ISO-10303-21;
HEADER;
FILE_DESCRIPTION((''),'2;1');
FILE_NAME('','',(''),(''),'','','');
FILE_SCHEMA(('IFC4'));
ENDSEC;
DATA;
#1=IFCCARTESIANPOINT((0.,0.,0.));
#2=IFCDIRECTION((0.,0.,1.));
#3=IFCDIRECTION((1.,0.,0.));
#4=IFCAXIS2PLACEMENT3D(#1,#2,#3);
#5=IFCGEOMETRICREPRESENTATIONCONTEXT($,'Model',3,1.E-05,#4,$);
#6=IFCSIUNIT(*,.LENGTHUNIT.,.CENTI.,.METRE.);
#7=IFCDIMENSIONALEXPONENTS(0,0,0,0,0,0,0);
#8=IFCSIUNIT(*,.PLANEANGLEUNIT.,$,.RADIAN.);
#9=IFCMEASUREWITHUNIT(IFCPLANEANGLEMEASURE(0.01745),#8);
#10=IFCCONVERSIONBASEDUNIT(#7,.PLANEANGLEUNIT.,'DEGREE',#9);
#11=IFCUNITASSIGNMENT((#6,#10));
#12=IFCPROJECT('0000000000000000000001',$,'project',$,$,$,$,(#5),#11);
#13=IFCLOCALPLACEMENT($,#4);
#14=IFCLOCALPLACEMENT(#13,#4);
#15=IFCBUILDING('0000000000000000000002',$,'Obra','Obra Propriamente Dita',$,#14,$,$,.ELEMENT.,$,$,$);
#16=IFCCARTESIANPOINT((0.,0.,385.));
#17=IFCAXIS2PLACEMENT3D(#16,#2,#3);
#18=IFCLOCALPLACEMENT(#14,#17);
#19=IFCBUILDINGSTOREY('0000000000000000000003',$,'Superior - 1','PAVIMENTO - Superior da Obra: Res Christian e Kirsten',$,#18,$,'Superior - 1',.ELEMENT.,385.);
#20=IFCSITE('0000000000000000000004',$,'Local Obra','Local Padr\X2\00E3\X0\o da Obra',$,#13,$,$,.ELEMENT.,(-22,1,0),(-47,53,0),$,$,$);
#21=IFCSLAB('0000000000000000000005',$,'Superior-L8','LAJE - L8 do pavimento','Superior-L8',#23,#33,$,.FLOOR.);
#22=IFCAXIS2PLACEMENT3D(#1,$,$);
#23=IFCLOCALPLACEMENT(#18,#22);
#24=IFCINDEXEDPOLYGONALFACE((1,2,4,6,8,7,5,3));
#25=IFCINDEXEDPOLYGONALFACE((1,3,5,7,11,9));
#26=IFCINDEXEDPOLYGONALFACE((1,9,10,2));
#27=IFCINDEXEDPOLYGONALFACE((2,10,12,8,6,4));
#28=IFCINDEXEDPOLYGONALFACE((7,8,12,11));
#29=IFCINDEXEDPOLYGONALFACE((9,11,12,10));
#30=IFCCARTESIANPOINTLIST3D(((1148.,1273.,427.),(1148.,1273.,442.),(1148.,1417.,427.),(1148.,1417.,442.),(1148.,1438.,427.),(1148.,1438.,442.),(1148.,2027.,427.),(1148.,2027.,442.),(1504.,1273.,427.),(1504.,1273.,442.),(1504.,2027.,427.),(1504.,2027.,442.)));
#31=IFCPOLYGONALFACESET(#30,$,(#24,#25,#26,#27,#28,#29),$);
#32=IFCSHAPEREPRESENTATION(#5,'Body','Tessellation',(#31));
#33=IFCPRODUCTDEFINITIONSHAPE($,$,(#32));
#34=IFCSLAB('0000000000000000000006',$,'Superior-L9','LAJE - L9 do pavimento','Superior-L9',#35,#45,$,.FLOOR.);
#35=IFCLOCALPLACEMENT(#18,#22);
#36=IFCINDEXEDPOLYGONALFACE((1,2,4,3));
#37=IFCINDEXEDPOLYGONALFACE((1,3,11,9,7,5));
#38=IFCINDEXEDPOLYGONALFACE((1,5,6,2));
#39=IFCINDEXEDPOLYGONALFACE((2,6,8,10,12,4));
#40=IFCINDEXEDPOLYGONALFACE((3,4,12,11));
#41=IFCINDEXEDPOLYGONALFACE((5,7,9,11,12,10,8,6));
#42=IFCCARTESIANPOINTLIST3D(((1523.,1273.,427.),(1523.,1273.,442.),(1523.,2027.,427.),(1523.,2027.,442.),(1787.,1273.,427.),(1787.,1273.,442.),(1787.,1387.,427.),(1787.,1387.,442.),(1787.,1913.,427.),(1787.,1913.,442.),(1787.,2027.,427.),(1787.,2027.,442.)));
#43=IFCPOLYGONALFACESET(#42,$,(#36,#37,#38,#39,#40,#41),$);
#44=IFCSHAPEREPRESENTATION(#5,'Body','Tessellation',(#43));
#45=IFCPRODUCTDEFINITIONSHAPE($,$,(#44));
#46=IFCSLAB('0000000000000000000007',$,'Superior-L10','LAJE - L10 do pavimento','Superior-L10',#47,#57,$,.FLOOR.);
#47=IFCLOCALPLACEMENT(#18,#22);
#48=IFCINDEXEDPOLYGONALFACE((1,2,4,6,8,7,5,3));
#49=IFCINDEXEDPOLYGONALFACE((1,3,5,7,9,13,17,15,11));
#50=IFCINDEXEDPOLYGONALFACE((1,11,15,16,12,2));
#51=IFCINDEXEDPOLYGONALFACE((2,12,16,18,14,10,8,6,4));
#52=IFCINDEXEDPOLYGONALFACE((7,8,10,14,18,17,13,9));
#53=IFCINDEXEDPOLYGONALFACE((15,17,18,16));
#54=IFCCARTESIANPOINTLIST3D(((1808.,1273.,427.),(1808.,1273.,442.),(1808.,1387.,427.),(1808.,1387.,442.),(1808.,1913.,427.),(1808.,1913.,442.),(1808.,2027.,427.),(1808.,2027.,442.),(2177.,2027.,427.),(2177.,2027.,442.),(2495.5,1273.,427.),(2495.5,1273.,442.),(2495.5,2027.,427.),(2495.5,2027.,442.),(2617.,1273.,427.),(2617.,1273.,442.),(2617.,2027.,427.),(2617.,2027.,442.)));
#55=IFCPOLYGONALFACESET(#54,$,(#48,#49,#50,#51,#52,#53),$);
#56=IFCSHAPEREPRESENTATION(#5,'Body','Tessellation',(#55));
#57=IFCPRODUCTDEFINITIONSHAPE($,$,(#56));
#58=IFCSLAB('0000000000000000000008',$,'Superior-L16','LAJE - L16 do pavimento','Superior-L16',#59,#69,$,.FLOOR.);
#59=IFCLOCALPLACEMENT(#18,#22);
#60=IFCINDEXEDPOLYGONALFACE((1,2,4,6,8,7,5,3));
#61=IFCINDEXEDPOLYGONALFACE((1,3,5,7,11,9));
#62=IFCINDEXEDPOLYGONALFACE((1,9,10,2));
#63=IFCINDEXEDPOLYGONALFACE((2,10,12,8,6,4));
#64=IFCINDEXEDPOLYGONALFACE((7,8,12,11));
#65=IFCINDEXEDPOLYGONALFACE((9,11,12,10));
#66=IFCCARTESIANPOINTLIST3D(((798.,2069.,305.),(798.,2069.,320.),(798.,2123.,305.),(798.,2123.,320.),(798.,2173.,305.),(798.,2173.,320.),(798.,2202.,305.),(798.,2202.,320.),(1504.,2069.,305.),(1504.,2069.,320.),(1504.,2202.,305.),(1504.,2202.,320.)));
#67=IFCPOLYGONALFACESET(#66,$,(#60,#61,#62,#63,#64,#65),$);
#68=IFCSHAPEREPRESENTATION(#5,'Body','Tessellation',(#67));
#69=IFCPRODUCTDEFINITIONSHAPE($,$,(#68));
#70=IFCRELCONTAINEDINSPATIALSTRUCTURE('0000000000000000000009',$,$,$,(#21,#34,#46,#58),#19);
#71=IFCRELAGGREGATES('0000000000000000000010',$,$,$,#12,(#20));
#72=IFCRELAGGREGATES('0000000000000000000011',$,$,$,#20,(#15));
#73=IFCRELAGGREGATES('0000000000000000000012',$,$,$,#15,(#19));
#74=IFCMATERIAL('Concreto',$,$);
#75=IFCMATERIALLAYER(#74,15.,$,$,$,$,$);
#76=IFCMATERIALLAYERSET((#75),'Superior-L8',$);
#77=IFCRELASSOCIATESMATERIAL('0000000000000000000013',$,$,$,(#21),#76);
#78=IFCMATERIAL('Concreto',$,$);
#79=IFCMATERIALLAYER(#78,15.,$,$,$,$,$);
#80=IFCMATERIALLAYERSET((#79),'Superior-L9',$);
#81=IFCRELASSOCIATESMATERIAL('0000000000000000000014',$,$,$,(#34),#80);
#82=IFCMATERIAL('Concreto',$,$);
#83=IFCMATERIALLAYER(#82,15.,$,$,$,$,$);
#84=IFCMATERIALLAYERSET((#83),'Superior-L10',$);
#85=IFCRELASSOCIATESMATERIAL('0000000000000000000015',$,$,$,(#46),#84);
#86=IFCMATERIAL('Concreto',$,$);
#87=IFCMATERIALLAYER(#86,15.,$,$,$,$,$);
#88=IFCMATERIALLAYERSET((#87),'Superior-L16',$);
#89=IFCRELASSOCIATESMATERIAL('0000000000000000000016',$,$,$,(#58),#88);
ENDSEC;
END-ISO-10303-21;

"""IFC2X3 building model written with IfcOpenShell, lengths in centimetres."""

from ifc_helpers import new_model, entity, si_unit, converted_unit, frame, origin_with_axes, place, context, project, spatial, polyline, outline, extrude, material, layer, layer_set, layer_usage, element, save


model = new_model("IFC2X3")

# Units and contexts
model_context = context("Model", 3, precision=1e-05, world=origin_with_axes())
ifc_project = project(units=[si_unit("LENGTHUNIT", "METRE", prefix="CENTI"), converted_unit("PLANEANGLEUNIT", "DEGREE", entity("IfcPlaneAngleMeasure", 0.01745), si_unit("PLANEANGLEUNIT", "RADIAN"), dimensions=[0, 0, 0, 0, 0, 0, 0])], contexts=[model_context])

# Site, building, storey
site_placement = place(None, origin_with_axes())
site = spatial("IfcSite", under=ifc_project, at=site_placement, Name="Local Obra", Description="Local Padrão da Obra", CompositionType="ELEMENT", RefLatitude=(-22, 1, 0), RefLongitude=(-47, 53, 0))
building_placement = place(site_placement, origin_with_axes())
building = spatial("IfcBuilding", under=site, at=building_placement, Name="Obra", Description="Obra Propriamente Dita", CompositionType="ELEMENT")
storey_placement = place(building_placement, frame((0.0, 0.0, 385.0), z_axis=(0.0, 0.0, 1.0), x_axis=(1.0, 0.0, 0.0)))
storey = spatial("IfcBuildingStorey", under=building, at=storey_placement, Name="Superior - 1", Description="PAVIMENTO - Superior da Obra: Res Christian e Kirsten", LongName="Superior - 1", CompositionType="ELEMENT", Elevation=385.0)

# Slabs
ifc_material_1 = material(Name="Concreto")
ifc_layer_1 = layer(ifc_material_1, 15.0)
ifc_layer_set_1 = layer_set([ifc_layer_1], Name="Superior-L8")
ifc_layer_usage_1 = layer_usage(ifc_layer_set_1, "AXIS3", "POSITIVE", 0.0)
slab_1_placement = place(storey_placement, frame((1504.0, 1273.0, 427.0), z_axis=(0.0, 0.0, 1.0), x_axis=(1.0, 0.0, 0.0)))
element("IfcSlab", 1, at=slab_1_placement, inside=storey, material=ifc_layer_usage_1, Name="Superior-L8", Description="LAJE - L8 do pavimento", ObjectType="Superior-L8", PredefinedType="FLOOR", context=model_context, shape_type="SweptSolid", body=[
    extrude(outline(polyline([(0.0, 754.0), (-356.0, 754.0), (-356.0, 165.0), (-356.0, 144.0), (-356.0, 0.0), (0.0, 0.0), (0.0, 754.0)])), origin_with_axes(), (0.0, 0.0, 1.0), 15.0),
])
ifc_material_2 = material(Name="Concreto")
ifc_layer_2 = layer(ifc_material_2, 15.0)
ifc_layer_set_2 = layer_set([ifc_layer_2], Name="Superior-L9")
ifc_layer_usage_2 = layer_usage(ifc_layer_set_2, "AXIS3", "POSITIVE", 0.0)
slab_2_placement = place(storey_placement, frame((1787.0, 1913.0, 427.0), z_axis=(0.0, 0.0, 1.0), x_axis=(1.0, 0.0, 0.0)))
element("IfcSlab", 2, at=slab_2_placement, inside=storey, material=ifc_layer_usage_2, Name="Superior-L9", Description="LAJE - L9 do pavimento", ObjectType="Superior-L9", PredefinedType="FLOOR", context=model_context, shape_type="SweptSolid", body=[
    extrude(outline(polyline([(0.0, 114.0), (-264.0, 114.0), (-264.0, -640.0), (0.0, -640.0), (0.0, -526.0), (0.0, 0.0), (0.0, 114.0)])), origin_with_axes(), (0.0, 0.0, 1.0), 15.0),
])
ifc_material_3 = material(Name="Concreto")
ifc_layer_3 = layer(ifc_material_3, 15.0)
ifc_layer_set_3 = layer_set([ifc_layer_3], Name="Superior-L10")
ifc_layer_usage_3 = layer_usage(ifc_layer_set_3, "AXIS3", "POSITIVE", 0.0)
slab_3_placement = place(storey_placement, frame((2617.0, 2027.0, 427.0), z_axis=(0.0, 0.0, 1.0), x_axis=(1.0, 0.0, 0.0)))
element("IfcSlab", 3, at=slab_3_placement, inside=storey, material=ifc_layer_usage_3, Name="Superior-L10", Description="LAJE - L10 do pavimento", ObjectType="Superior-L10", PredefinedType="FLOOR", context=model_context, shape_type="SweptSolid", body=[
    extrude(outline(polyline([(-121.5, 0.0), (-440.0, 0.0), (-809.0, 0.0), (-809.0, -114.0), (-809.0, -640.0), (-809.0, -754.0), (-121.5, -754.0), (0.0, -754.0), (0.0, 0.0), (-121.5, 0.0)])), origin_with_axes(), (0.0, 0.0, 1.0), 15.0),
])
ifc_material_4 = material(Name="Concreto")
ifc_layer_4 = layer(ifc_material_4, 15.0)
ifc_layer_set_4 = layer_set([ifc_layer_4], Name="Superior-L16")
ifc_layer_usage_4 = layer_usage(ifc_layer_set_4, "AXIS3", "POSITIVE", 0.0)
slab_4_placement = place(storey_placement, frame((1504.0, 2069.0, 305.0), z_axis=(0.0, 0.0, 1.0), x_axis=(1.0, 0.0, 0.0)))
element("IfcSlab", 4, at=slab_4_placement, inside=storey, material=ifc_layer_usage_4, Name="Superior-L16", Description="LAJE - L16 do pavimento", ObjectType="Superior-L16", PredefinedType="FLOOR", context=model_context, shape_type="SweptSolid", body=[
    extrude(outline(polyline([(0.0, 133.0), (-706.0, 133.0), (-706.0, 104.0), (-706.0, 54.0), (-706.0, 0.0), (0.0, 0.0), (0.0, 133.0)])), origin_with_axes(), (0.0, 0.0, 1.0), 15.0),
])

save(model, "model.ifc")
